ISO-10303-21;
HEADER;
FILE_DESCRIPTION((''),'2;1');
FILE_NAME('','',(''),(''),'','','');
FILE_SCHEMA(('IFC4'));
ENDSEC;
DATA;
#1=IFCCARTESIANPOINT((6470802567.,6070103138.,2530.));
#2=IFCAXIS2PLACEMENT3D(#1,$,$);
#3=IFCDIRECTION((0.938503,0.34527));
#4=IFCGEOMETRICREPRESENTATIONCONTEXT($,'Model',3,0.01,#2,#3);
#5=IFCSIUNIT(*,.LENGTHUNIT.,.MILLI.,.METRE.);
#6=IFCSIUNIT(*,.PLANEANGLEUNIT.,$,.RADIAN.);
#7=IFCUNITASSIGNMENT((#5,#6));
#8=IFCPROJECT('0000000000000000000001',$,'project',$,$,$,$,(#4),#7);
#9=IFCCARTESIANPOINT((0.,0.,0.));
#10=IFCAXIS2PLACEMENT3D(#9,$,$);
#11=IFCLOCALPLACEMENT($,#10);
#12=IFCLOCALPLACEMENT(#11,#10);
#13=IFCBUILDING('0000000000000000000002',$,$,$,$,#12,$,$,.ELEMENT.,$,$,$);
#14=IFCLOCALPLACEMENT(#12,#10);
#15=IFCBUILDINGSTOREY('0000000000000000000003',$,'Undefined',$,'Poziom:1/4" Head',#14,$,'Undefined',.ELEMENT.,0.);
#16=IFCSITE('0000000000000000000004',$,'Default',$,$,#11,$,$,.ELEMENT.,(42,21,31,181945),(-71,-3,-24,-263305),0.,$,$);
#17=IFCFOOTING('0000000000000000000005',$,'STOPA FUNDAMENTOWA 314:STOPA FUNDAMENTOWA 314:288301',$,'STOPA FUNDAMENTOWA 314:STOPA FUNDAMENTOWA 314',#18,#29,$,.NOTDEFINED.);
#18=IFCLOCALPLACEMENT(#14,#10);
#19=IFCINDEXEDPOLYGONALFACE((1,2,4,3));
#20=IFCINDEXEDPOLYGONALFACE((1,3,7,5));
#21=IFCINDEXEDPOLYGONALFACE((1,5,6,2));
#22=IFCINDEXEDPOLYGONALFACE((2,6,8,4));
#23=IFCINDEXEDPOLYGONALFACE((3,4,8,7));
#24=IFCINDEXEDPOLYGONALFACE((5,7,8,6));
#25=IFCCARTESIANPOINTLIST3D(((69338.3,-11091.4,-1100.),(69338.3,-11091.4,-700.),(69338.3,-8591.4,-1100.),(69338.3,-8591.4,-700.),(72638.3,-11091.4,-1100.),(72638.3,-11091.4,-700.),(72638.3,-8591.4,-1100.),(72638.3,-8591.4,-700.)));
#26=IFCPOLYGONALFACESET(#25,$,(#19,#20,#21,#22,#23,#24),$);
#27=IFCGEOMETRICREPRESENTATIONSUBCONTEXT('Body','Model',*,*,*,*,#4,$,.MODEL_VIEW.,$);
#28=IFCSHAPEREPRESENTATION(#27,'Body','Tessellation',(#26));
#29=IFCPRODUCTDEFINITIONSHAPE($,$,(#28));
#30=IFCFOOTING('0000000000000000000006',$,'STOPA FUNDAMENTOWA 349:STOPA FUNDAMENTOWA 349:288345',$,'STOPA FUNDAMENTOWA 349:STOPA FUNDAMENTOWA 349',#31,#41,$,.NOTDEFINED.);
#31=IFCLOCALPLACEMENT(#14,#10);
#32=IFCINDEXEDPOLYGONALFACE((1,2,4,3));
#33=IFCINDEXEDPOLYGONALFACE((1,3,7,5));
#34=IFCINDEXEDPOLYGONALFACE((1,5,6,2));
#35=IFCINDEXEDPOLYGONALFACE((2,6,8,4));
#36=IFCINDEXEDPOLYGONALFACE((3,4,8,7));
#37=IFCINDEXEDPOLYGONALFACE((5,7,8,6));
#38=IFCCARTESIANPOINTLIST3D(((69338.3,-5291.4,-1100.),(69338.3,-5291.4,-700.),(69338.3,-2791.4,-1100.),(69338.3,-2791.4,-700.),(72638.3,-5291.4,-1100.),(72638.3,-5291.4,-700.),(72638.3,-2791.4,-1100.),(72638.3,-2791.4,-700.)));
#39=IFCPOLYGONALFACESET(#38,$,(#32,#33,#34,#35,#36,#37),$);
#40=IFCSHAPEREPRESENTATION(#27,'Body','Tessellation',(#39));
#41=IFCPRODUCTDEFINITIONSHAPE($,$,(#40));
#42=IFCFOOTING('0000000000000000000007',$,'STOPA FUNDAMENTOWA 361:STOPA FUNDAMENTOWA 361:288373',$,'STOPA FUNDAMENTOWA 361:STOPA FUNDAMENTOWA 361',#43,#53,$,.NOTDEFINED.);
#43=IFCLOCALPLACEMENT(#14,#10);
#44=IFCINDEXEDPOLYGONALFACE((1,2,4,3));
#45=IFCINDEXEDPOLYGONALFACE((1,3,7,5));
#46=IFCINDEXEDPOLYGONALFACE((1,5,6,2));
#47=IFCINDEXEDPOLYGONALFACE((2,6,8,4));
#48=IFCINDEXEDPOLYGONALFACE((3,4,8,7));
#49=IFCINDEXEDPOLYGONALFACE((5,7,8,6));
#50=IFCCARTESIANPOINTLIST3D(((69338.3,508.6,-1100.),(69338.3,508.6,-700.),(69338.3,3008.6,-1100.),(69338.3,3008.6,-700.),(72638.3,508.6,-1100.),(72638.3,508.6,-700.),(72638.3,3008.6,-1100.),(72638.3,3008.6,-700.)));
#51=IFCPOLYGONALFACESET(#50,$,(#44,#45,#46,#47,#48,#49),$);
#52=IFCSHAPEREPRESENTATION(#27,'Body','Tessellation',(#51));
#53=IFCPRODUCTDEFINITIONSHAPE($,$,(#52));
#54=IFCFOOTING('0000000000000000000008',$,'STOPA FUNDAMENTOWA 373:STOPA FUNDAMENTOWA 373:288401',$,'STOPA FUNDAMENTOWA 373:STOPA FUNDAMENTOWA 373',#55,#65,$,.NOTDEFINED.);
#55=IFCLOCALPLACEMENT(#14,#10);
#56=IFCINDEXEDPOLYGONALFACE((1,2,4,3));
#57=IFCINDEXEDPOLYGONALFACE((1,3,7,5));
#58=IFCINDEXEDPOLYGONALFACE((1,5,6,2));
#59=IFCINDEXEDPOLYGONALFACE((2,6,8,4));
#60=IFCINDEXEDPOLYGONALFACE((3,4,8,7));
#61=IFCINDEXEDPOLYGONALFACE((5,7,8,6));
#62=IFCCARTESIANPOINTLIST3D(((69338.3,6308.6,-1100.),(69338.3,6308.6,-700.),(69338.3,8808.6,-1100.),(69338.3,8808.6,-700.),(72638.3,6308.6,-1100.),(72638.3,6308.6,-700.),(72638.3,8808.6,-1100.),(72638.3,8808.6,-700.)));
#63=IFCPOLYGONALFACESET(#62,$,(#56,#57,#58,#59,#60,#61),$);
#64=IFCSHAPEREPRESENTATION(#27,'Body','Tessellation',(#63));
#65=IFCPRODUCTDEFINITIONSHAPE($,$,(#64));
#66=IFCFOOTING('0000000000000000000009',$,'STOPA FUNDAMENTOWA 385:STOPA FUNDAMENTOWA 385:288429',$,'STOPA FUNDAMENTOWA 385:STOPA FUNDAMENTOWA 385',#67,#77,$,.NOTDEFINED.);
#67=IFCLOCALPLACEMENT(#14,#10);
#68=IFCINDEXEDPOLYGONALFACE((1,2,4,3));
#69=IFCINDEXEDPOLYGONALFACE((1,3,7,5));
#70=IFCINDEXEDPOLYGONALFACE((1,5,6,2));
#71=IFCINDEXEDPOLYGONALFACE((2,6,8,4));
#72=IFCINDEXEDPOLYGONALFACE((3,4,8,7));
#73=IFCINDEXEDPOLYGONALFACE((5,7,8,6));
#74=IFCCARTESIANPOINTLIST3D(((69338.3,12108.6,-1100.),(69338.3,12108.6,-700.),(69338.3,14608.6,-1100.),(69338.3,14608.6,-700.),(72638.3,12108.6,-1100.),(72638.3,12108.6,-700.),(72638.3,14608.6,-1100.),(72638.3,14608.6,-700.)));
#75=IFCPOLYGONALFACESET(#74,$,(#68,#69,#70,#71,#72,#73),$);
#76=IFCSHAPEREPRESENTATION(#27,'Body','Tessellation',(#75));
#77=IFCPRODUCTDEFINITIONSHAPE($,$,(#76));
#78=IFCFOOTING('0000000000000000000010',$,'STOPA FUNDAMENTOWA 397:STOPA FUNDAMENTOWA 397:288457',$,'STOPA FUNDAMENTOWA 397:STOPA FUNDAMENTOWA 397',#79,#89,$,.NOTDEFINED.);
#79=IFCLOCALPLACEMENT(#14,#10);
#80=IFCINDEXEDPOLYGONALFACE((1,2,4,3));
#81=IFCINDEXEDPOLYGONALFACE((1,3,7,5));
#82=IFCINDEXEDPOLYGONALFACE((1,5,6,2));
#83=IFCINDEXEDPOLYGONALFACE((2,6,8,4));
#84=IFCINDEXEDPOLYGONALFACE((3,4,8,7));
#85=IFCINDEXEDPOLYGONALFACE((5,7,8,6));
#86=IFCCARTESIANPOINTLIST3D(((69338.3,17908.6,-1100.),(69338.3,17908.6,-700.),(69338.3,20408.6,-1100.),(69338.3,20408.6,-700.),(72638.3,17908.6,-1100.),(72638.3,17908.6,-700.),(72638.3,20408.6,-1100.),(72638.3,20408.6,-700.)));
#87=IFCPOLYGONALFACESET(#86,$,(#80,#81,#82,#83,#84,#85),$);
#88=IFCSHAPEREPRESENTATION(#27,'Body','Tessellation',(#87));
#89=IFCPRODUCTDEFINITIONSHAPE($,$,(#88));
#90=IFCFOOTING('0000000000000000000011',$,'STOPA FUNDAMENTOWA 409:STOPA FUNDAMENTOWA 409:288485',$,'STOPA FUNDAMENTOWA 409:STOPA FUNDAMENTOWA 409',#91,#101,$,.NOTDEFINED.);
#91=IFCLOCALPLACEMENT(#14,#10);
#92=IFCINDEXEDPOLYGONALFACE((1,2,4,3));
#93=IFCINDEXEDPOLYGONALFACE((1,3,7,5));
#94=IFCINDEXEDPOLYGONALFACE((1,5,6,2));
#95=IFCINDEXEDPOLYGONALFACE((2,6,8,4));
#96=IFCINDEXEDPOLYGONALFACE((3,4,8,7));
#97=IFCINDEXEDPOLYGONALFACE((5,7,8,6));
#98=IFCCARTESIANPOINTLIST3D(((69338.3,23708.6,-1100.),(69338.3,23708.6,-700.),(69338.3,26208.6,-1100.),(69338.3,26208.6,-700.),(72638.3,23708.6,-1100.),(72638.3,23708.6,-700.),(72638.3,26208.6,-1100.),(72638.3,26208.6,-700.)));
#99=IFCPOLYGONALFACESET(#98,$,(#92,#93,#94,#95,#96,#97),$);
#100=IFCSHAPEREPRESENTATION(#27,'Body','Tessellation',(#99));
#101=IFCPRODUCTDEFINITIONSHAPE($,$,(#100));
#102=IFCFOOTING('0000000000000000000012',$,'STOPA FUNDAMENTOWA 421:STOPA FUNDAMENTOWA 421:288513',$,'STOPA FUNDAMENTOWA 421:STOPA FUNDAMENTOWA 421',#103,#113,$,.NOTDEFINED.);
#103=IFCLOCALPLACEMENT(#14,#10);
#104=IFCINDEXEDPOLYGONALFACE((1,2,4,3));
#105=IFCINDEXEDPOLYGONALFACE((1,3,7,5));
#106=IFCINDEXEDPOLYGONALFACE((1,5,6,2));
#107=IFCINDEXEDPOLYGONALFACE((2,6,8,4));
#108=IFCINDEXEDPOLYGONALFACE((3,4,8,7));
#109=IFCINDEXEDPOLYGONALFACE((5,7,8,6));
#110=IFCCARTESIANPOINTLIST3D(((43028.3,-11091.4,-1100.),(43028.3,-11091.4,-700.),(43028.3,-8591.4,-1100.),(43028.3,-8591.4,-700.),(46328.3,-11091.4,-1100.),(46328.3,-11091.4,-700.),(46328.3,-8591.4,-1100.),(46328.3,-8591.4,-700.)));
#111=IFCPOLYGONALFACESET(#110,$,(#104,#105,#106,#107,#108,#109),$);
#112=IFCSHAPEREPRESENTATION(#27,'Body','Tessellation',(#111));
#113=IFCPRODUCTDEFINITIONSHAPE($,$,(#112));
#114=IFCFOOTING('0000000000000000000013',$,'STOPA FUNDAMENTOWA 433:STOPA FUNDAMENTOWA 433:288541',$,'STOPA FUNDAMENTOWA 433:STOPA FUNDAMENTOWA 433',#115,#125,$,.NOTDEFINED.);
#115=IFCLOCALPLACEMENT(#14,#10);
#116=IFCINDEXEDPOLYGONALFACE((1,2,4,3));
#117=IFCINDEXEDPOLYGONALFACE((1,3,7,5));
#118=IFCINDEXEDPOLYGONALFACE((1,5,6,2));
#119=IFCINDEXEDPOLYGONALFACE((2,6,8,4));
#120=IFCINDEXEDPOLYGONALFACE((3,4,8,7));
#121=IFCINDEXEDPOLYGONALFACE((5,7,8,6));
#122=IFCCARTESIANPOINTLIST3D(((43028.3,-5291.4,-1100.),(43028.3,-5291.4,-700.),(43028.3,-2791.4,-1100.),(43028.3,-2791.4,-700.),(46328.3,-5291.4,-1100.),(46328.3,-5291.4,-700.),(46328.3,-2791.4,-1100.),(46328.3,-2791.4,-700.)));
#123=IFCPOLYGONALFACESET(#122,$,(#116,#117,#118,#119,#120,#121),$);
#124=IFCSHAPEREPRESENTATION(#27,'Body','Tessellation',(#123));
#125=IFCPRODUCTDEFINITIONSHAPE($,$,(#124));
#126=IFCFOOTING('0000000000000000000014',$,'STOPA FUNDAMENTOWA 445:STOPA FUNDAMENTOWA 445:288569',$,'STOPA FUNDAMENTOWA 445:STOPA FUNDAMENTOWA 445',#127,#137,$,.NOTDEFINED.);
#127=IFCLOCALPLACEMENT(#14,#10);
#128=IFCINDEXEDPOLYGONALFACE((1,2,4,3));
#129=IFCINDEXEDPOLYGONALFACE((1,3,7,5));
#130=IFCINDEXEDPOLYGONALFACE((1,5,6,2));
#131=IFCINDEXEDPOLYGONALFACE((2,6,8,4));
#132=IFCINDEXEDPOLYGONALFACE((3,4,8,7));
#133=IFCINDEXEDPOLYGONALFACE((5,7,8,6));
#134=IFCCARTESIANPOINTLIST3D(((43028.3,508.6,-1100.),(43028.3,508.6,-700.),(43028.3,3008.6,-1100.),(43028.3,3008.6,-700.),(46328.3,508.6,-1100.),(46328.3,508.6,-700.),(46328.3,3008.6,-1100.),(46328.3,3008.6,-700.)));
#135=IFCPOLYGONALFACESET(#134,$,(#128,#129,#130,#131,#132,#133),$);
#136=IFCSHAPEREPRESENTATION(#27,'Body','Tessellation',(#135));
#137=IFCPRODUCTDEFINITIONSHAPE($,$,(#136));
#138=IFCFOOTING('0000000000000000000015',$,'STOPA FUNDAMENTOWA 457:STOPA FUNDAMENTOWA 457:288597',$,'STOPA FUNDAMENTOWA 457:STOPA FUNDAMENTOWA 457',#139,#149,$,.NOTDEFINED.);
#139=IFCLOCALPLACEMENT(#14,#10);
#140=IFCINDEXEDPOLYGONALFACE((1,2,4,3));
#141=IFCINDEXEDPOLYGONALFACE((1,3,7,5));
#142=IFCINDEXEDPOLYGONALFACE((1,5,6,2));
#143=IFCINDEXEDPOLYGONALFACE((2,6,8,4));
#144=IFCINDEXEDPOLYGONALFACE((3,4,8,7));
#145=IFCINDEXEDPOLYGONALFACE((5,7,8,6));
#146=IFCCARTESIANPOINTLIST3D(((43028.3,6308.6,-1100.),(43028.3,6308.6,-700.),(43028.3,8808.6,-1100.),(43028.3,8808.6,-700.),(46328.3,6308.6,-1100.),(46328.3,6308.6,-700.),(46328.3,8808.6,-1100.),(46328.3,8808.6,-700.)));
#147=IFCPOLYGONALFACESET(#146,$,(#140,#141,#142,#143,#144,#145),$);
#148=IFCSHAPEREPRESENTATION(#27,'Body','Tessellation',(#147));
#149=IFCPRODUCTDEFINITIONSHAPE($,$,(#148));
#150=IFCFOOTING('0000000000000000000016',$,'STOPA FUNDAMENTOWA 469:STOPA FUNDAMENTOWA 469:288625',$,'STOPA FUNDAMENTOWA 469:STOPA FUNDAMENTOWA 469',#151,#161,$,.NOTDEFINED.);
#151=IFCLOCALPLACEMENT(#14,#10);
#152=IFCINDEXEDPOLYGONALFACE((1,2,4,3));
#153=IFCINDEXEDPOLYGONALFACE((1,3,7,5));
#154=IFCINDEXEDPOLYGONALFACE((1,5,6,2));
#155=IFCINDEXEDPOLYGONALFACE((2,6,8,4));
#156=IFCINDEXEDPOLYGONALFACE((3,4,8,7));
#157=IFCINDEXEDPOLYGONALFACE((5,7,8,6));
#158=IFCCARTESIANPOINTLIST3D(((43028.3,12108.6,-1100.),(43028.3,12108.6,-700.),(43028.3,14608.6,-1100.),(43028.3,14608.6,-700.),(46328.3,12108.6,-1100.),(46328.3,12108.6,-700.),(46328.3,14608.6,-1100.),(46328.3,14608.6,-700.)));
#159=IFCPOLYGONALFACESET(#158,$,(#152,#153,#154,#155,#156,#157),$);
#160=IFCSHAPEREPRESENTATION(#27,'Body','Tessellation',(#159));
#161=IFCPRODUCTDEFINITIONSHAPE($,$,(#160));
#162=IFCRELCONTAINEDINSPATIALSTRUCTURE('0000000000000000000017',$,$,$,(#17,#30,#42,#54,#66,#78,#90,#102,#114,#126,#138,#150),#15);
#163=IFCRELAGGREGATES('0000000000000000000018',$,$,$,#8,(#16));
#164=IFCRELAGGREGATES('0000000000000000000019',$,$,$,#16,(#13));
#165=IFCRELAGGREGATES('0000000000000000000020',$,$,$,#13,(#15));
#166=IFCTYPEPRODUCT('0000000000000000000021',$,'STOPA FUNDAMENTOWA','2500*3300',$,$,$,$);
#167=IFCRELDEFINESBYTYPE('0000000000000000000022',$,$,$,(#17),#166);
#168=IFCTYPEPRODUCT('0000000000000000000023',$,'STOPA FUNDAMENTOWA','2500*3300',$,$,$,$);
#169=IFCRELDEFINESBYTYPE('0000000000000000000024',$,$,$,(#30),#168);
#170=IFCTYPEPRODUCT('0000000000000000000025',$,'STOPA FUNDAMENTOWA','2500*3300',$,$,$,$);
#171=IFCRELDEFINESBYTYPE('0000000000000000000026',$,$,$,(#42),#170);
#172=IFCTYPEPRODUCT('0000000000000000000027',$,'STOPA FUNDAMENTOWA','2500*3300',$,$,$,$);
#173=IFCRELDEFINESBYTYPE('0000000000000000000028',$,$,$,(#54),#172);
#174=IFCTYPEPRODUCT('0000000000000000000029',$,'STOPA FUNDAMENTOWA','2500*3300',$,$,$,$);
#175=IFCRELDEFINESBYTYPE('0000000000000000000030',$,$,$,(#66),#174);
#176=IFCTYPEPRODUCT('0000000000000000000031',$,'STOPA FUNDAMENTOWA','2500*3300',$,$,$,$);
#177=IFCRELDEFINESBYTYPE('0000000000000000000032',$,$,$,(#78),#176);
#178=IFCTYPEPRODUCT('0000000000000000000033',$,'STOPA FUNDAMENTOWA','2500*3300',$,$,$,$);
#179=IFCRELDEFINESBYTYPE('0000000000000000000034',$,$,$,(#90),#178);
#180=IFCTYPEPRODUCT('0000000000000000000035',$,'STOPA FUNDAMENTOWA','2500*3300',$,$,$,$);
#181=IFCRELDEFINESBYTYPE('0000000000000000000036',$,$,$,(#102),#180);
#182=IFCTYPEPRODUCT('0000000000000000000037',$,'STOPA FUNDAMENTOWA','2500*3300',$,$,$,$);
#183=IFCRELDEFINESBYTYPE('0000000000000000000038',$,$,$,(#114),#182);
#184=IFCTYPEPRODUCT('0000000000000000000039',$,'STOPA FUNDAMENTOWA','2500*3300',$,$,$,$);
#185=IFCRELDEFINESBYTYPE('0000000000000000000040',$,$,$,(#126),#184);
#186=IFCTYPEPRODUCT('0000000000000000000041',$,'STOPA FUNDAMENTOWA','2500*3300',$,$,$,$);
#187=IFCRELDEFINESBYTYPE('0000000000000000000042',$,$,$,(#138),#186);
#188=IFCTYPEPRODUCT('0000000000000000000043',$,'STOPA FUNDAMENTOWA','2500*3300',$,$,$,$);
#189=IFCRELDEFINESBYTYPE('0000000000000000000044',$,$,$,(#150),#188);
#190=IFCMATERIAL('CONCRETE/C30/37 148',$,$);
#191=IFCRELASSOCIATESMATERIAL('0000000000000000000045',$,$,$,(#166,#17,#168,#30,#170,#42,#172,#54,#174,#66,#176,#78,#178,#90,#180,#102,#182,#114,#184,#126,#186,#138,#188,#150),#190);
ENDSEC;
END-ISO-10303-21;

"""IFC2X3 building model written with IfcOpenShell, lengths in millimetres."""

from ifc_helpers import new_model, si_unit, direction, frame, frame_2d, origin, origin_2d_with_axis, place, context, subcontext, project, spatial, rectangle, extrude, source, transform, mapped, material, type_object, type_shapes, element, save


model = new_model("IFC2X3")

# Units and contexts
model_context = context("Model", 3, precision=0.01, world=frame((6470802567.0, 6070103138.0, 2530.0)), true_north=direction((0.938503, 0.34527)))
body_context = subcontext(model_context, "Body", "Model", "MODEL_VIEW")
ifc_project = project(units=[si_unit("LENGTHUNIT", "METRE", prefix="MILLI"), si_unit("PLANEANGLEUNIT", "RADIAN")], contexts=[model_context])

# Site, building, storey
site_placement = place(None, origin())
site = spatial("IfcSite", under=ifc_project, at=site_placement, Name="Default", CompositionType="ELEMENT", RefLatitude=(42, 21, 31, 181945), RefLongitude=(-71, -3, -24, -263305), RefElevation=0.0)
building_placement = place(site_placement, origin())
building = spatial("IfcBuilding", under=site, at=building_placement, CompositionType="ELEMENT")
storey_placement = place(building_placement, origin())
storey = spatial("IfcBuildingStorey", under=building, at=storey_placement, Name="Undefined", ObjectType="Poziom:1/4\" Head", LongName="Undefined", CompositionType="ELEMENT", Elevation=0.0)

# Footings
ifc_material = material(Name="CONCRETE/C30/37 148")
type_product_1 = type_object("IfcTypeProduct", Name="STOPA FUNDAMENTOWA", Description="2500*3300", material=ifc_material)
shared_shape_1 = source(origin(), body_context, "Body", "SweptSolid", [
    extrude(rectangle(XDim=2500.0, YDim=3300.0, at=frame_2d((0.0, 0.0), x_axis=(1.0, 0.0))), frame((70988.3, -9841.4, -1100.0), z_axis=(0.0, 0.0, 1.0), x_axis=(0.0, 1.0, 0.0)), (0.0, 0.0, 1.0), 400.0),
])
type_shapes(type_product_1, [shared_shape_1])
footing_1_placement = place(storey_placement, origin())
element("IfcFooting", 1, at=footing_1_placement, inside=storey, type_object=type_product_1, material=ifc_material, Name="STOPA FUNDAMENTOWA 314:STOPA FUNDAMENTOWA 314:288301", ObjectType="STOPA FUNDAMENTOWA 314:STOPA FUNDAMENTOWA 314", PredefinedType="NOTDEFINED", context=body_context, shape_type="MappedRepresentation", body=[
    mapped(shared_shape_1, transform((0.0, 0.0, 0.0), scale=1.0)),
])
type_product_2 = type_object("IfcTypeProduct", Name="STOPA FUNDAMENTOWA", Description="2500*3300", material=ifc_material)
shared_shape_2 = source(origin(), body_context, "Body", "SweptSolid", [
    extrude(rectangle(XDim=2500.0, YDim=3300.0, at=frame_2d((0.0, 0.0), x_axis=(1.0, 0.0))), frame((70988.3, -4041.4, -1100.0), z_axis=(0.0, 0.0, 1.0), x_axis=(0.0, 1.0, 0.0)), (0.0, 0.0, 1.0), 400.0),
])
type_shapes(type_product_2, [shared_shape_2])
footing_2_placement = place(storey_placement, origin())
element("IfcFooting", 2, at=footing_2_placement, inside=storey, type_object=type_product_2, material=ifc_material, Name="STOPA FUNDAMENTOWA 349:STOPA FUNDAMENTOWA 349:288345", ObjectType="STOPA FUNDAMENTOWA 349:STOPA FUNDAMENTOWA 349", PredefinedType="NOTDEFINED", context=body_context, shape_type="MappedRepresentation", body=[
    mapped(shared_shape_2, transform((0.0, 0.0, 0.0), scale=1.0)),
])
type_product_3 = type_object("IfcTypeProduct", Name="STOPA FUNDAMENTOWA", Description="2500*3300", material=ifc_material)
shared_shape_3 = source(origin(), body_context, "Body", "SweptSolid", [
    extrude(rectangle(XDim=2500.0, YDim=3300.0, at=frame_2d((0.0, 0.0), x_axis=(1.0, 0.0))), frame((70988.3, 1758.6, -1100.0), z_axis=(0.0, 0.0, 1.0), x_axis=(0.0, 1.0, 0.0)), (0.0, 0.0, 1.0), 400.0),
])
type_shapes(type_product_3, [shared_shape_3])
footing_3_placement = place(storey_placement, origin())
element("IfcFooting", 3, at=footing_3_placement, inside=storey, type_object=type_product_3, material=ifc_material, Name="STOPA FUNDAMENTOWA 361:STOPA FUNDAMENTOWA 361:288373", ObjectType="STOPA FUNDAMENTOWA 361:STOPA FUNDAMENTOWA 361", PredefinedType="NOTDEFINED", context=body_context, shape_type="MappedRepresentation", body=[
    mapped(shared_shape_3, transform((0.0, 0.0, 0.0), scale=1.0)),
])
type_product_4 = type_object("IfcTypeProduct", Name="STOPA FUNDAMENTOWA", Description="2500*3300", material=ifc_material)
shared_shape_4 = source(origin(), body_context, "Body", "SweptSolid", [
    extrude(rectangle(XDim=2500.0, YDim=3300.0, at=frame_2d((0.0, 0.0), x_axis=(1.0, 0.0))), frame((70988.3, 7558.6, -1100.0), z_axis=(0.0, 0.0, 1.0), x_axis=(0.0, 1.0, 0.0)), (0.0, 0.0, 1.0), 400.0),
])
type_shapes(type_product_4, [shared_shape_4])
footing_4_placement = place(storey_placement, origin())
element("IfcFooting", 4, at=footing_4_placement, inside=storey, type_object=type_product_4, material=ifc_material, Name="STOPA FUNDAMENTOWA 373:STOPA FUNDAMENTOWA 373:288401", ObjectType="STOPA FUNDAMENTOWA 373:STOPA FUNDAMENTOWA 373", PredefinedType="NOTDEFINED", context=body_context, shape_type="MappedRepresentation", body=[
    mapped(shared_shape_4, transform((0.0, 0.0, 0.0), scale=1.0)),
])
type_product_5 = type_object("IfcTypeProduct", Name="STOPA FUNDAMENTOWA", Description="2500*3300", material=ifc_material)
shared_shape_5 = source(origin(), body_context, "Body", "SweptSolid", [
    extrude(rectangle(XDim=2500.0, YDim=3300.0, at=frame_2d((0.0, 0.0), x_axis=(1.0, 0.0))), frame((70988.3, 13358.6, -1100.0), z_axis=(0.0, 0.0, 1.0), x_axis=(0.0, 1.0, 0.0)), (0.0, 0.0, 1.0), 400.0),
])
type_shapes(type_product_5, [shared_shape_5])
footing_5_placement = place(storey_placement, origin())
element("IfcFooting", 5, at=footing_5_placement, inside=storey, type_object=type_product_5, material=ifc_material, Name="STOPA FUNDAMENTOWA 385:STOPA FUNDAMENTOWA 385:288429", ObjectType="STOPA FUNDAMENTOWA 385:STOPA FUNDAMENTOWA 385", PredefinedType="NOTDEFINED", context=body_context, shape_type="MappedRepresentation", body=[
    mapped(shared_shape_5, transform((0.0, 0.0, 0.0), scale=1.0)),
])
type_product_6 = type_object("IfcTypeProduct", Name="STOPA FUNDAMENTOWA", Description="2500*3300", material=ifc_material)
shared_shape_6 = source(origin(), body_context, "Body", "SweptSolid", [
    extrude(rectangle(XDim=2500.0, YDim=3300.0, at=frame_2d((0.0, 0.0), x_axis=(1.0, 0.0))), frame((70988.3, 19158.6, -1100.0), z_axis=(0.0, 0.0, 1.0), x_axis=(0.0, 1.0, 0.0)), (0.0, 0.0, 1.0), 400.0),
])
type_shapes(type_product_6, [shared_shape_6])
footing_6_placement = place(storey_placement, origin())
element("IfcFooting", 6, at=footing_6_placement, inside=storey, type_object=type_product_6, material=ifc_material, Name="STOPA FUNDAMENTOWA 397:STOPA FUNDAMENTOWA 397:288457", ObjectType="STOPA FUNDAMENTOWA 397:STOPA FUNDAMENTOWA 397", PredefinedType="NOTDEFINED", context=body_context, shape_type="MappedRepresentation", body=[
    mapped(shared_shape_6, transform((0.0, 0.0, 0.0), scale=1.0)),
])
type_product_7 = type_object("IfcTypeProduct", Name="STOPA FUNDAMENTOWA", Description="2500*3300", material=ifc_material)
shared_shape_7 = source(origin(), body_context, "Body", "SweptSolid", [
    extrude(rectangle(XDim=2500.0, YDim=3300.0, at=frame_2d((0.0, 0.0), x_axis=(1.0, 0.0))), frame((70988.3, 24958.6, -1100.0), z_axis=(0.0, 0.0, 1.0), x_axis=(0.0, 1.0, 0.0)), (0.0, 0.0, 1.0), 400.0),
])
type_shapes(type_product_7, [shared_shape_7])
footing_7_placement = place(storey_placement, origin())
element("IfcFooting", 7, at=footing_7_placement, inside=storey, type_object=type_product_7, material=ifc_material, Name="STOPA FUNDAMENTOWA 409:STOPA FUNDAMENTOWA 409:288485", ObjectType="STOPA FUNDAMENTOWA 409:STOPA FUNDAMENTOWA 409", PredefinedType="NOTDEFINED", context=body_context, shape_type="MappedRepresentation", body=[
    mapped(shared_shape_7, transform((0.0, 0.0, 0.0), scale=1.0)),
])
type_product_8 = type_object("IfcTypeProduct", Name="STOPA FUNDAMENTOWA", Description="2500*3300", material=ifc_material)
shared_shape_8 = source(origin(), body_context, "Body", "SweptSolid", [
    extrude(rectangle(XDim=2500.0, YDim=3300.0, at=origin_2d_with_axis()), frame((44678.3, -9841.4, -1100.0), z_axis=(0.0, 0.0, 1.0), x_axis=(0.0, -1.0, 0.0)), (0.0, 0.0, 1.0), 400.0),
])
type_shapes(type_product_8, [shared_shape_8])
footing_8_placement = place(storey_placement, origin())
element("IfcFooting", 8, at=footing_8_placement, inside=storey, type_object=type_product_8, material=ifc_material, Name="STOPA FUNDAMENTOWA 421:STOPA FUNDAMENTOWA 421:288513", ObjectType="STOPA FUNDAMENTOWA 421:STOPA FUNDAMENTOWA 421", PredefinedType="NOTDEFINED", context=body_context, shape_type="MappedRepresentation", body=[
    mapped(shared_shape_8, transform((0.0, 0.0, 0.0), scale=1.0)),
])
type_product_9 = type_object("IfcTypeProduct", Name="STOPA FUNDAMENTOWA", Description="2500*3300", material=ifc_material)
shared_shape_9 = source(origin(), body_context, "Body", "SweptSolid", [
    extrude(rectangle(XDim=2500.0, YDim=3300.0, at=origin_2d_with_axis()), frame((44678.3, -4041.4, -1100.0), z_axis=(0.0, 0.0, 1.0), x_axis=(0.0, -1.0, 0.0)), (0.0, 0.0, 1.0), 400.0),
])
type_shapes(type_product_9, [shared_shape_9])
footing_9_placement = place(storey_placement, origin())
element("IfcFooting", 9, at=footing_9_placement, inside=storey, type_object=type_product_9, material=ifc_material, Name="STOPA FUNDAMENTOWA 433:STOPA FUNDAMENTOWA 433:288541", ObjectType="STOPA FUNDAMENTOWA 433:STOPA FUNDAMENTOWA 433", PredefinedType="NOTDEFINED", context=body_context, shape_type="MappedRepresentation", body=[
    mapped(shared_shape_9, transform((0.0, 0.0, 0.0), scale=1.0)),
])
type_product_10 = type_object("IfcTypeProduct", Name="STOPA FUNDAMENTOWA", Description="2500*3300", material=ifc_material)
shared_shape_10 = source(origin(), body_context, "Body", "SweptSolid", [
    extrude(rectangle(XDim=2500.0, YDim=3300.0, at=origin_2d_with_axis()), frame((44678.3, 1758.6, -1100.0), z_axis=(0.0, 0.0, 1.0), x_axis=(0.0, -1.0, 0.0)), (0.0, 0.0, 1.0), 400.0),
])
type_shapes(type_product_10, [shared_shape_10])
footing_10_placement = place(storey_placement, origin())
element("IfcFooting", 10, at=footing_10_placement, inside=storey, type_object=type_product_10, material=ifc_material, Name="STOPA FUNDAMENTOWA 445:STOPA FUNDAMENTOWA 445:288569", ObjectType="STOPA FUNDAMENTOWA 445:STOPA FUNDAMENTOWA 445", PredefinedType="NOTDEFINED", context=body_context, shape_type="MappedRepresentation", body=[
    mapped(shared_shape_10, transform((0.0, 0.0, 0.0), scale=1.0)),
])
type_product_11 = type_object("IfcTypeProduct", Name="STOPA FUNDAMENTOWA", Description="2500*3300", material=ifc_material)
shared_shape_11 = source(origin(), body_context, "Body", "SweptSolid", [
    extrude(rectangle(XDim=2500.0, YDim=3300.0, at=origin_2d_with_axis()), frame((44678.3, 7558.6, -1100.0), z_axis=(0.0, 0.0, 1.0), x_axis=(0.0, -1.0, 0.0)), (0.0, 0.0, 1.0), 400.0),
])
type_shapes(type_product_11, [shared_shape_11])
footing_11_placement = place(storey_placement, origin())
element("IfcFooting", 11, at=footing_11_placement, inside=storey, type_object=type_product_11, material=ifc_material, Name="STOPA FUNDAMENTOWA 457:STOPA FUNDAMENTOWA 457:288597", ObjectType="STOPA FUNDAMENTOWA 457:STOPA FUNDAMENTOWA 457", PredefinedType="NOTDEFINED", context=body_context, shape_type="MappedRepresentation", body=[
    mapped(shared_shape_11, transform((0.0, 0.0, 0.0), scale=1.0)),
])
type_product_12 = type_object("IfcTypeProduct", Name="STOPA FUNDAMENTOWA", Description="2500*3300", material=ifc_material)
shared_shape_12 = source(origin(), body_context, "Body", "SweptSolid", [
    extrude(rectangle(XDim=2500.0, YDim=3300.0, at=origin_2d_with_axis()), frame((44678.3, 13358.6, -1100.0), z_axis=(0.0, 0.0, 1.0), x_axis=(0.0, -1.0, 0.0)), (0.0, 0.0, 1.0), 400.0),
])
type_shapes(type_product_12, [shared_shape_12])
footing_12_placement = place(storey_placement, origin())
element("IfcFooting", 12, at=footing_12_placement, inside=storey, type_object=type_product_12, material=ifc_material, Name="STOPA FUNDAMENTOWA 469:STOPA FUNDAMENTOWA 469:288625", ObjectType="STOPA FUNDAMENTOWA 469:STOPA FUNDAMENTOWA 469", PredefinedType="NOTDEFINED", context=body_context, shape_type="MappedRepresentation", body=[
    mapped(shared_shape_12, transform((0.0, 0.0, 0.0), scale=1.0)),
])

save(model, "model.ifc")
